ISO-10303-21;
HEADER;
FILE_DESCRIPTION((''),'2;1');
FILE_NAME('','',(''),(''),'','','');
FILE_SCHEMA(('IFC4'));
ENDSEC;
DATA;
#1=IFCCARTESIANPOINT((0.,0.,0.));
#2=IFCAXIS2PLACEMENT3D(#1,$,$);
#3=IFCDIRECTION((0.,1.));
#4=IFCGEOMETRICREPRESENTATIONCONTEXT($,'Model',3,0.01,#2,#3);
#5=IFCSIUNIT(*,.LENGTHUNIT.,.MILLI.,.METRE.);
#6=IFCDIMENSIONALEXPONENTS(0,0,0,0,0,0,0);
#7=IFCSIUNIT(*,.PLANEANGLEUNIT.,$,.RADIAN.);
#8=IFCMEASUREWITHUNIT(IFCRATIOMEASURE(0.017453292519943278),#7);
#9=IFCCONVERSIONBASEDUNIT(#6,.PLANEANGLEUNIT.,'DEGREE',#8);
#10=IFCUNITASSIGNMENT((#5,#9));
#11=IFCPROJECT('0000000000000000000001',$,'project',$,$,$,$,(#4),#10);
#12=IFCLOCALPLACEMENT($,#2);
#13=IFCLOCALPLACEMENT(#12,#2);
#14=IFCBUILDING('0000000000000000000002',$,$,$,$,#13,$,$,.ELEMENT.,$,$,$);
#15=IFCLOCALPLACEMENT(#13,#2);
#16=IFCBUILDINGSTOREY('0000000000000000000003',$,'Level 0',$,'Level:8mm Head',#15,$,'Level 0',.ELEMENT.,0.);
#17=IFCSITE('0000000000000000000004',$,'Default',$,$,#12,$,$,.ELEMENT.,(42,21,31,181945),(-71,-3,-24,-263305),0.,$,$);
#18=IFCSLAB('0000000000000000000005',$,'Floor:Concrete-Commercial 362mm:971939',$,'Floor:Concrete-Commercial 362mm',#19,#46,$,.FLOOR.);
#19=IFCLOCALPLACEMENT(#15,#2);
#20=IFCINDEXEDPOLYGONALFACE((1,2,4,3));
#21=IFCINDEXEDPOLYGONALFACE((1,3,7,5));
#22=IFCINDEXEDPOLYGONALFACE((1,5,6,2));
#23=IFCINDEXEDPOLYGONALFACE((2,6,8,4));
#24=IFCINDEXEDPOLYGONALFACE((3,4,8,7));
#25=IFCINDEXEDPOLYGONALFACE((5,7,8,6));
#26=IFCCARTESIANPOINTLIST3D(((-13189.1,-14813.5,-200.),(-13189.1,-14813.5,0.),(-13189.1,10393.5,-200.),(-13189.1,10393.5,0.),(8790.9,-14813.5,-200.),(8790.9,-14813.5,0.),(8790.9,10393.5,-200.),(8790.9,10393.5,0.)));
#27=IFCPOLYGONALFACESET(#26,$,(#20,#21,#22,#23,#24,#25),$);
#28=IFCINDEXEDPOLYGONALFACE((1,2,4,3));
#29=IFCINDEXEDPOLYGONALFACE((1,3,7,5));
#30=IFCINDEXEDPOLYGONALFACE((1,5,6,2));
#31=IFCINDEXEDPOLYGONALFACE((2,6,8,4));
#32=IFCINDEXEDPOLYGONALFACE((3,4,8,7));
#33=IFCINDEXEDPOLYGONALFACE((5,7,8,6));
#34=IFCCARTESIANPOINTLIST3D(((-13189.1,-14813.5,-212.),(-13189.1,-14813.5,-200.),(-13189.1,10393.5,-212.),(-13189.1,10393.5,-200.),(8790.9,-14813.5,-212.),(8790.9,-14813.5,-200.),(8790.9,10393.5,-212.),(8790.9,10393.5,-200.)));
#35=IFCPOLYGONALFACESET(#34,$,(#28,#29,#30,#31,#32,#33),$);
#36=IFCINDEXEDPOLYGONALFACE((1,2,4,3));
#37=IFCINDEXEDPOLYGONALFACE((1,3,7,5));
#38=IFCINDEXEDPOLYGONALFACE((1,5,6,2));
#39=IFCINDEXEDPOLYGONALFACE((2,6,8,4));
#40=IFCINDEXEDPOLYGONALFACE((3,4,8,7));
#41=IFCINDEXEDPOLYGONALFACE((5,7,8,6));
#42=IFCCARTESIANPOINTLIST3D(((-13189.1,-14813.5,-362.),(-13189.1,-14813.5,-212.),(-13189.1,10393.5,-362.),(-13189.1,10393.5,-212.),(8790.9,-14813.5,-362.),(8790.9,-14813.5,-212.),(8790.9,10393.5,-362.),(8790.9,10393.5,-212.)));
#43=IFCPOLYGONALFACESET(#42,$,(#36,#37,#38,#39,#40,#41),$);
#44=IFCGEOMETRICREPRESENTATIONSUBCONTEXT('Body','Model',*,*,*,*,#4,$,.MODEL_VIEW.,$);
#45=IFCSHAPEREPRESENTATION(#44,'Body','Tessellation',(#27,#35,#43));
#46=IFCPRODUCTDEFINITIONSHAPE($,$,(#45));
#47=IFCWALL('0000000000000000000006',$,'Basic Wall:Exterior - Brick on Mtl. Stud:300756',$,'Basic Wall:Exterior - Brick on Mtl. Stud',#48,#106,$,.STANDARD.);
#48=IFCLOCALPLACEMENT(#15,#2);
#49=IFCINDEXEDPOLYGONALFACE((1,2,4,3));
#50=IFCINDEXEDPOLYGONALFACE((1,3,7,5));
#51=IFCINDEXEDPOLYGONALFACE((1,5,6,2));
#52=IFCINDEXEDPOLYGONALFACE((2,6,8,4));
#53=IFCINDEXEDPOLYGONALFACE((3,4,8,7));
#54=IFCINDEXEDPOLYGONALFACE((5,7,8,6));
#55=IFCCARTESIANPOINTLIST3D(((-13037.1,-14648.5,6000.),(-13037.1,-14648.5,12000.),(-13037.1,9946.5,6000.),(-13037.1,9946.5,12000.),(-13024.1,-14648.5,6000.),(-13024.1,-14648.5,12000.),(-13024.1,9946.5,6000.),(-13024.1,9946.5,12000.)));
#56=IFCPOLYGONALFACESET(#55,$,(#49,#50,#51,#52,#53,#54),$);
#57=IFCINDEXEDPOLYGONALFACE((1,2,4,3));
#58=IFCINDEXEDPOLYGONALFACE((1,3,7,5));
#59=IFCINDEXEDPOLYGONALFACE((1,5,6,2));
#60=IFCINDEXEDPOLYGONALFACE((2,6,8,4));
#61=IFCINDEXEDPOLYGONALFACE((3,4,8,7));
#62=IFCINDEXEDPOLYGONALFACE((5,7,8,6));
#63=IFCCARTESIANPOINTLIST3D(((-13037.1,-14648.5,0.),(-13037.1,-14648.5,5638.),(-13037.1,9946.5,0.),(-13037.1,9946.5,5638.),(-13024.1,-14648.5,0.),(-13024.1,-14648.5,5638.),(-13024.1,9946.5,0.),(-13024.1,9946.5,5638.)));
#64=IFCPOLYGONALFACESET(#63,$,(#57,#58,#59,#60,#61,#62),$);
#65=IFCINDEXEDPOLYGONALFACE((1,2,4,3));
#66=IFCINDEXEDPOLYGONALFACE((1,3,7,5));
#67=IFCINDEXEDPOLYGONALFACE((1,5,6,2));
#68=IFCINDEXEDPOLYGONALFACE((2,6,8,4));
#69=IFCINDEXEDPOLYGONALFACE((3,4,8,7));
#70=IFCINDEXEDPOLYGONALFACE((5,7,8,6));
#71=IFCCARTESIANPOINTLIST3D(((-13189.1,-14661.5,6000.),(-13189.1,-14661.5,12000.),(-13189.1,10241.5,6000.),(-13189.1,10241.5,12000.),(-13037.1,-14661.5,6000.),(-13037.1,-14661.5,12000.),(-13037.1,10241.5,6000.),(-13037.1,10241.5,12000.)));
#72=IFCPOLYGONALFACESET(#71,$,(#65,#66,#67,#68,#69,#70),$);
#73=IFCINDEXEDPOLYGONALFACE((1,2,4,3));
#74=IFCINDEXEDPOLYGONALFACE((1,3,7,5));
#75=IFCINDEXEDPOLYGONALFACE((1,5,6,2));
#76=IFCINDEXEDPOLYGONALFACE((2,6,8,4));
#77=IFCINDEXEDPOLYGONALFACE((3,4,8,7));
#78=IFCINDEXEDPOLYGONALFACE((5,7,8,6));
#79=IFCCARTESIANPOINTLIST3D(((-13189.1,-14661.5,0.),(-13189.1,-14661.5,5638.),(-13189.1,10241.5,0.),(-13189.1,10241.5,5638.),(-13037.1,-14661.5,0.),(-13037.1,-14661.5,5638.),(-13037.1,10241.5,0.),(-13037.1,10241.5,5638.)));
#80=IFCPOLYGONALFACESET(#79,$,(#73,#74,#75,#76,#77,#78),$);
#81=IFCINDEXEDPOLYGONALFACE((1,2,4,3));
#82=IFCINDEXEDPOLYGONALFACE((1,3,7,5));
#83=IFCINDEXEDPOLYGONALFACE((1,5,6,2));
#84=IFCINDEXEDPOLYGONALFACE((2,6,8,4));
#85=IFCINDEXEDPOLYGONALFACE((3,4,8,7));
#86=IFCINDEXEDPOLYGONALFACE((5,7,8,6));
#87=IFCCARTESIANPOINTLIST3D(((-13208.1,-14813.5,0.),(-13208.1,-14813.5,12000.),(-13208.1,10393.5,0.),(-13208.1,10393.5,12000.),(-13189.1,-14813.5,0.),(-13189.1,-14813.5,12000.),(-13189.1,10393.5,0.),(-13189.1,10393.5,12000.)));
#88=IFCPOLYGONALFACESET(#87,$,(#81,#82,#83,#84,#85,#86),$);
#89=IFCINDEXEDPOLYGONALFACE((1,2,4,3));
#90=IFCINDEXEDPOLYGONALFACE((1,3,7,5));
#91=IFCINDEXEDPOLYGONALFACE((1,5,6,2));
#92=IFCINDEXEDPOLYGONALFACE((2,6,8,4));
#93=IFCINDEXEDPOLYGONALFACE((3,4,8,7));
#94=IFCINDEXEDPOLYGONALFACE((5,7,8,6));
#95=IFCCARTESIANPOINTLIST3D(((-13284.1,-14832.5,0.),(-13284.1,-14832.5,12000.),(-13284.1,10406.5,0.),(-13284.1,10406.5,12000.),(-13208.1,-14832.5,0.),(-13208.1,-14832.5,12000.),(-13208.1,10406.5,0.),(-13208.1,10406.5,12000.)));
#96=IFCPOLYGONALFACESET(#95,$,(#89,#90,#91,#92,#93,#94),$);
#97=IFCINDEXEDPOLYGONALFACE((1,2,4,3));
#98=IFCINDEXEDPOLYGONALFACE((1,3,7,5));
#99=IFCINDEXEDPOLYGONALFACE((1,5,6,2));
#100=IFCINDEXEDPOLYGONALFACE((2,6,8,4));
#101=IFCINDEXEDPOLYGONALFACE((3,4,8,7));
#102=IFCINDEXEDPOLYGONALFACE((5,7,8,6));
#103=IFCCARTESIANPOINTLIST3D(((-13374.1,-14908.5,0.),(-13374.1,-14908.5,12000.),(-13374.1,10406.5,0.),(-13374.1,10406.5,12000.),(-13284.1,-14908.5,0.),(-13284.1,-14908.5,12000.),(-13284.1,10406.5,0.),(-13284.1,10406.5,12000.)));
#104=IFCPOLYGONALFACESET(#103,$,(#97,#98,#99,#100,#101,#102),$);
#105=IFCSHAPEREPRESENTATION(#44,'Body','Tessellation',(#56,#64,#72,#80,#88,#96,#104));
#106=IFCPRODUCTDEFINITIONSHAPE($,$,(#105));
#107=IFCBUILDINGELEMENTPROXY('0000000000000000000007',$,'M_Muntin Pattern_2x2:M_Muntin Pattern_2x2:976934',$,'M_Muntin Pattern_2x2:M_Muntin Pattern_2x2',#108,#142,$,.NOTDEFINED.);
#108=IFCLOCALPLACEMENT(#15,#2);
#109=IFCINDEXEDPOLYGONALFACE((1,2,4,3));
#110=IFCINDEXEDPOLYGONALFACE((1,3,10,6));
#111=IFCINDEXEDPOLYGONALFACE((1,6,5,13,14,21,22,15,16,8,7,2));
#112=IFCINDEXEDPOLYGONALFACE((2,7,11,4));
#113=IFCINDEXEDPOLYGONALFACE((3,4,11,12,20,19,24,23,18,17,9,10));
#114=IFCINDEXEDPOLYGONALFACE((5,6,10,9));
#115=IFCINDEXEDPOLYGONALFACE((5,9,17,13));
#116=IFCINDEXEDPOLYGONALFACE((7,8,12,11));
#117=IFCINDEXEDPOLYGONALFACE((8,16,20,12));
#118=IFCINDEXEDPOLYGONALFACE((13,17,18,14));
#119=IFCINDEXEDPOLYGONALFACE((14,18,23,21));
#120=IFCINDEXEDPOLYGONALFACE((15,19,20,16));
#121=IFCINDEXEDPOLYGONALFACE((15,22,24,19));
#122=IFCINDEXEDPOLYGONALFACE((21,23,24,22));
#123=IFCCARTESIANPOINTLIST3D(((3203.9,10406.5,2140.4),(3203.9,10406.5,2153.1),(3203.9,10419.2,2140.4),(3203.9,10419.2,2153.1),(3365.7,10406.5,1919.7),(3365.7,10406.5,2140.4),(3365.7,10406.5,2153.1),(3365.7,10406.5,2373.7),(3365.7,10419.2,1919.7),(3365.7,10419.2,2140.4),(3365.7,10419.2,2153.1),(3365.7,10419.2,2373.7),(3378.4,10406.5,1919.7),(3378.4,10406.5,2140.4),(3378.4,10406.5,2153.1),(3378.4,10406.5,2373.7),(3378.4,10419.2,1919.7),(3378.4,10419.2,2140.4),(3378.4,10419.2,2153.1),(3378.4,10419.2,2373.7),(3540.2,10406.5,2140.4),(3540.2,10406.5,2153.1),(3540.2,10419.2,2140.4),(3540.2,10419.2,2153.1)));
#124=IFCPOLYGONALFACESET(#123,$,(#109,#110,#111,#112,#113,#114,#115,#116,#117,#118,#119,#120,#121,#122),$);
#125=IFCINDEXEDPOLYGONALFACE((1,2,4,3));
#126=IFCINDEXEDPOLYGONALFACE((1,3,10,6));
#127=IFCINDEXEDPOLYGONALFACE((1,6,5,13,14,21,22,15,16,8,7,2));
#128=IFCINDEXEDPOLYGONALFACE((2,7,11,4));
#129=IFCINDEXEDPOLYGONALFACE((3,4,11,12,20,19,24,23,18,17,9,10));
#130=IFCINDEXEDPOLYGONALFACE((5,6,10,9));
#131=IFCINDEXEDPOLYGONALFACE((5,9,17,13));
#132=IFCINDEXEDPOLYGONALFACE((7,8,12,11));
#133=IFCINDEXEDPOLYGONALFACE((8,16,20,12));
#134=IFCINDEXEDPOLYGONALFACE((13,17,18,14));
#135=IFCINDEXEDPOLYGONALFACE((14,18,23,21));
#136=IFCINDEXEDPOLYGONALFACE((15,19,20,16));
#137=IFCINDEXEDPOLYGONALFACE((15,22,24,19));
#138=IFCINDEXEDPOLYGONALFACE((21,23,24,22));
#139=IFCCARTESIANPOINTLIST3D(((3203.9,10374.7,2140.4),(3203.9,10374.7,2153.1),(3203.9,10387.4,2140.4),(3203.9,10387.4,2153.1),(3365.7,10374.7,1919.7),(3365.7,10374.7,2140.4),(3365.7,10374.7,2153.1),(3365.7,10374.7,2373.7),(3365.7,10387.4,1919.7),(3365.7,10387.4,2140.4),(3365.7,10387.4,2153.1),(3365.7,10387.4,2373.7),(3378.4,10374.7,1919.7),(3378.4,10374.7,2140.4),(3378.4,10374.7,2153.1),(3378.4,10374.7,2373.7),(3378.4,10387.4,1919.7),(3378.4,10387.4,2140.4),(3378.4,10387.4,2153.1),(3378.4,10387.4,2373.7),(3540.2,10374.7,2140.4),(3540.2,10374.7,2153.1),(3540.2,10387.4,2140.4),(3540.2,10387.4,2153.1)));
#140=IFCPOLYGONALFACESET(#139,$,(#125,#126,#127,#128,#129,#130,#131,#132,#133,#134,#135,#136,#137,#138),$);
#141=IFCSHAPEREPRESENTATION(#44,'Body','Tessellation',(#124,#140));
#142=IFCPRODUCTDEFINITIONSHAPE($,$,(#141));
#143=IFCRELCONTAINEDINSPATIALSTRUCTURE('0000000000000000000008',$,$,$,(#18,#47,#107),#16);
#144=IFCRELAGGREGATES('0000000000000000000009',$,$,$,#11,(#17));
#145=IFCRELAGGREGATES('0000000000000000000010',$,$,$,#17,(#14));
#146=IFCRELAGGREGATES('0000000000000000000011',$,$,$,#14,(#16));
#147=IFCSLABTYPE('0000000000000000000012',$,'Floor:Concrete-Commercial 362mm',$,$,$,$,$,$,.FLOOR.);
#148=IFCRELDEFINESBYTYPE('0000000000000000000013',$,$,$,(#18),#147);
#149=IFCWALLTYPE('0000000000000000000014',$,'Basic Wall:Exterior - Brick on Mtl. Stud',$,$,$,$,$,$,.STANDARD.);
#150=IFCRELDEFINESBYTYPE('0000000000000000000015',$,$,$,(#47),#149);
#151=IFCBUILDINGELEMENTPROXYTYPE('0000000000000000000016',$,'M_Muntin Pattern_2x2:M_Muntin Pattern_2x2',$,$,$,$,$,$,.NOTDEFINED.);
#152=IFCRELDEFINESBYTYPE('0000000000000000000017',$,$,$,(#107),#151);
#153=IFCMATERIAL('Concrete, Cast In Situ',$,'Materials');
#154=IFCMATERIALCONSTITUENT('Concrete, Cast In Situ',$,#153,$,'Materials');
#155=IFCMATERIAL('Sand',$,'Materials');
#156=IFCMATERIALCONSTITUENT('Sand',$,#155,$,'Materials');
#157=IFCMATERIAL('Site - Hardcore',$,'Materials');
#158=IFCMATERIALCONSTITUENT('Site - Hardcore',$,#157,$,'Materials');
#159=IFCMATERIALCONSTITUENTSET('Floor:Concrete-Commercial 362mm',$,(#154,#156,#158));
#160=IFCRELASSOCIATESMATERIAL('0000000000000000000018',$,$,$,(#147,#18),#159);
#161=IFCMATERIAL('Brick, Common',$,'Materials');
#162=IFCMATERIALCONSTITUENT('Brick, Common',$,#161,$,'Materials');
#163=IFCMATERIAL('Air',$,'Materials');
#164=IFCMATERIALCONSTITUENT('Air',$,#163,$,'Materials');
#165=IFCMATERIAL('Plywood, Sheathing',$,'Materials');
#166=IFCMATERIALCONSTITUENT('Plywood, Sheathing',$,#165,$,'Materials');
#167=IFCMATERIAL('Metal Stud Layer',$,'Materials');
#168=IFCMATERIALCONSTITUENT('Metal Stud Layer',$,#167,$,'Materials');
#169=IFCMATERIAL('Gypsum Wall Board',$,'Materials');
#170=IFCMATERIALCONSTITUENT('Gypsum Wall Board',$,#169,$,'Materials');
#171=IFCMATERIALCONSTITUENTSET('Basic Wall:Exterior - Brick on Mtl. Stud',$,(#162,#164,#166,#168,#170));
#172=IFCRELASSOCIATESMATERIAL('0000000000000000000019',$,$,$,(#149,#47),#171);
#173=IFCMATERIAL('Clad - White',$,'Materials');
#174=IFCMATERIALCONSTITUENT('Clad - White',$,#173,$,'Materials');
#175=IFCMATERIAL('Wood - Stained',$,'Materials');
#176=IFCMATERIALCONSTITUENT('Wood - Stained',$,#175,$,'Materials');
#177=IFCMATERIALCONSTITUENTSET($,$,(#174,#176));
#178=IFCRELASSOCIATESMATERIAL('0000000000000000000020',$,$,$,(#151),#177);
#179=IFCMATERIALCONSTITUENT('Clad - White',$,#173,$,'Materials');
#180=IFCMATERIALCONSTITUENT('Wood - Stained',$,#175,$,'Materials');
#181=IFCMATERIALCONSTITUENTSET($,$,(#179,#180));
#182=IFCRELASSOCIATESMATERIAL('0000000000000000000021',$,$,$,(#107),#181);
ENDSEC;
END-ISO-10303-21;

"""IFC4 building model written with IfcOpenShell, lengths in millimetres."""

from ifc_helpers import new_model, entity, si_unit, converted_unit, direction, frame, origin, place, context, subcontext, project, spatial, indexed_curve, outline, extrude, source, transform, mapped, material, constituent, constituent_set, type_object, type_shapes, element, save


model = new_model("IFC4")

# Units and contexts
model_context = context("Model", 3, precision=0.01, world=origin(), true_north=direction((0.0, 1.0)))
body_context = subcontext(model_context, "Body", "Model", "MODEL_VIEW")
ifc_project = project(units=[si_unit("LENGTHUNIT", "METRE", prefix="MILLI"), converted_unit("PLANEANGLEUNIT", "DEGREE", entity("IfcRatioMeasure", 0.017453292519943278), si_unit("PLANEANGLEUNIT", "RADIAN"), dimensions=[0, 0, 0, 0, 0, 0, 0])], contexts=[model_context])

# Site, building, storey
site_placement = place(None, origin())
site = spatial("IfcSite", under=ifc_project, at=site_placement, Name="Default", CompositionType="ELEMENT", RefLatitude=(42, 21, 31, 181945), RefLongitude=(-71, -3, -24, -263305), RefElevation=0.0)
building_placement = place(site_placement, origin())
building = spatial("IfcBuilding", under=site, at=building_placement, CompositionType="ELEMENT")
storey_placement = place(building_placement, origin())
storey = spatial("IfcBuildingStorey", under=building, at=storey_placement, Name="Level 0", ObjectType="Level:8mm Head", LongName="Level 0", CompositionType="ELEMENT", Elevation=0.0)

# Slab
ifc_material_1 = material(Name="Concrete, Cast In Situ", Category="Materials")
ifc_constituent_1 = constituent(ifc_material_1, Name="Concrete, Cast In Situ", Category="Materials")
ifc_material_2 = material(Name="Sand", Category="Materials")
ifc_constituent_2 = constituent(ifc_material_2, Name="Sand", Category="Materials")
ifc_material_3 = material(Name="Site - Hardcore", Category="Materials")
ifc_constituent_3 = constituent(ifc_material_3, Name="Site - Hardcore", Category="Materials")
ifc_constituent_set_1 = constituent_set(constituents=[ifc_constituent_1, ifc_constituent_2, ifc_constituent_3], Name="Floor:Concrete-Commercial 362mm")
slab_type = type_object("IfcSlabType", Name="Floor:Concrete-Commercial 362mm", PredefinedType="FLOOR", material=ifc_constituent_set_1)
slab_placement = place(storey_placement, origin())
element("IfcSlab", 1, at=slab_placement, inside=storey, type_object=slab_type, material=ifc_constituent_set_1, Name="Floor:Concrete-Commercial 362mm:971939", ObjectType="Floor:Concrete-Commercial 362mm", PredefinedType="FLOOR", context=body_context, shape_type="SweptSolid", body=[
    extrude(outline(indexed_curve([(-10990.0, -12603.5), (10990.0, -12603.5), (10990.0, 12603.5), (-10990.0, 12603.5), (-10990.0, -12603.5)], self_intersect=False)), frame((-2199.1, -2210.0, -200.0), z_axis=(0.0, 0.0, 1.0), x_axis=(-1.0, 0.0, 0.0)), (0.0, 0.0, 1.0), 200.0),
    extrude(outline(indexed_curve([(-10990.0, -12603.5), (10990.0, -12603.5), (10990.0, 12603.5), (-10990.0, 12603.5), (-10990.0, -12603.5)], self_intersect=False)), frame((-2199.1, -2210.0, -212.0), z_axis=(0.0, 0.0, 1.0), x_axis=(-1.0, 0.0, 0.0)), (0.0, 0.0, 1.0), 12.0),
    extrude(outline(indexed_curve([(-10990.0, -12603.5), (10990.0, -12603.5), (10990.0, 12603.5), (-10990.0, 12603.5), (-10990.0, -12603.5)], self_intersect=False)), frame((-2199.1, -2210.0, -362.0), z_axis=(0.0, 0.0, 1.0), x_axis=(-1.0, 0.0, 0.0)), (0.0, 0.0, 1.0), 150.0),
])

# Shared definitions
ifc_material_4 = material(Name="Air", Category="Materials")
ifc_material_5 = material(Name="Plywood, Sheathing", Category="Materials")
ifc_material_6 = material(Name="Metal Stud Layer", Category="Materials")
ifc_material_7 = material(Name="Gypsum Wall Board", Category="Materials")
ifc_material_8 = material(Name="Brick, Common", Category="Materials")
ifc_constituent_4 = constituent(ifc_material_8, Name="Brick, Common", Category="Materials")
ifc_constituent_5 = constituent(ifc_material_4, Name="Air", Category="Materials")
ifc_constituent_6 = constituent(ifc_material_5, Name="Plywood, Sheathing", Category="Materials")
ifc_constituent_7 = constituent(ifc_material_6, Name="Metal Stud Layer", Category="Materials")
ifc_constituent_8 = constituent(ifc_material_7, Name="Gypsum Wall Board", Category="Materials")
ifc_constituent_set_2 = constituent_set(constituents=[ifc_constituent_4, ifc_constituent_5, ifc_constituent_6, ifc_constituent_7, ifc_constituent_8], Name="Basic Wall:Exterior - Brick on Mtl. Stud")
wall_type_1 = type_object("IfcWallType", Name="Basic Wall:Exterior - Brick on Mtl. Stud", PredefinedType="STANDARD", material=ifc_constituent_set_2)

# Wall
wall_1_placement = place(storey_placement, frame((-13199.1, -14648.5, 0.0), z_axis=(0.0, 0.0, 1.0), x_axis=(0.0, 1.0, 0.0)))
element("IfcWall", 2, at=wall_1_placement, inside=storey, type_object=wall_type_1, material=ifc_constituent_set_2, Name="Basic Wall:Exterior - Brick on Mtl. Stud:300756", ObjectType="Basic Wall:Exterior - Brick on Mtl. Stud", PredefinedType="STANDARD", context=body_context, shape_type="SweptSolid", body=[
    extrude(outline(indexed_curve([(-3000.0, -12297.5), (3000.0, -12297.5), (3000.0, 12297.5), (-3000.0, 12297.5), (-3000.0, -12297.5)], self_intersect=False)), frame((12297.5, -162.0, 9000.0), z_axis=(0.0, -1.0, 0.0), x_axis=(0.0, 0.0, -1.0)), (0.0, 0.0, 1.0), 13.0),
    extrude(outline(indexed_curve([(-2819.0, -12297.5), (2819.0, -12297.5), (2819.0, 12297.5), (-2819.0, 12297.5), (-2819.0, -12297.5)], self_intersect=False)), frame((12297.5, -162.0, 2819.0), z_axis=(0.0, -1.0, 0.0), x_axis=(0.0, 0.0, 1.0)), (0.0, 0.0, 1.0), 13.0),
    extrude(outline(indexed_curve([(-3000.0, -12451.5), (3000.0, -12451.5), (3000.0, 12451.5), (-3000.0, 12451.5), (-3000.0, -12451.5)], self_intersect=False)), frame((12438.5, -10.0, 9000.0), z_axis=(0.0, -1.0, 0.0), x_axis=(0.0, 0.0, -1.0)), (0.0, 0.0, 1.0), 152.0),
    extrude(outline(indexed_curve([(-2819.0, -12451.5), (2819.0, -12451.5), (2819.0, 12451.5), (-2819.0, 12451.5), (-2819.0, -12451.5)], self_intersect=False)), frame((12438.5, -10.0, 2819.0), z_axis=(0.0, -1.0, 0.0), x_axis=(0.0, 0.0, 1.0)), (0.0, 0.0, 1.0), 152.0),
    extrude(outline(indexed_curve([(-12603.5, -9.5), (12603.5, -9.5), (12603.5, 9.5), (-12603.5, 9.5), (-12603.5, -9.5)], self_intersect=False)), frame((12438.5, -0.5, 0.0)), (0.0, 0.0, 1.0), 12000.0),
    extrude(outline(indexed_curve([(-12619.5, -38.0), (12619.5, -38.0), (12619.5, 38.0), (-12619.5, 38.0), (-12619.5, -38.0)], self_intersect=False)), frame((12435.5, 47.0, 0.0)), (0.0, 0.0, 1.0), 12000.0),
    extrude(outline(indexed_curve([(-45.0, -12657.5), (45.0, -12657.5), (45.0, 12657.5), (-45.0, 12657.5), (-45.0, -12657.5)], self_intersect=False)), frame((12397.5, 130.0, 0.0), z_axis=(0.0, 0.0, 1.0), x_axis=(0.0, -1.0, 0.0)), (0.0, 0.0, 1.0), 12000.0),
])

# Building element proxy
ifc_material_9 = material(Name="Clad - White", Category="Materials")
ifc_constituent_9 = constituent(ifc_material_9, Name="Clad - White", Category="Materials")
ifc_material_10 = material(Name="Wood - Stained", Category="Materials")
ifc_constituent_10 = constituent(ifc_material_10, Name="Wood - Stained", Category="Materials")
ifc_constituent_set_3 = constituent_set(constituents=[ifc_constituent_9, ifc_constituent_10])
ifc_constituent_11 = constituent(ifc_material_9, Name="Clad - White", Category="Materials")
ifc_constituent_12 = constituent(ifc_material_10, Name="Wood - Stained", Category="Materials")
ifc_constituent_set_4 = constituent_set(constituents=[ifc_constituent_11, ifc_constituent_12])
building_element_proxy_type_1 = type_object("IfcBuildingElementProxyType", Name="M_Muntin Pattern_2x2:M_Muntin Pattern_2x2", PredefinedType="NOTDEFINED", material=ifc_constituent_set_4)
shared_shape_1 = source(origin(), body_context, "Body", "SweptSolid", [
    extrude(outline(indexed_curve([(6.4, -6.4), (227.0, -6.4), (227.0, 6.3), (6.4, 6.3), (6.4, 168.2), (-6.3, 168.2), (-6.3, 6.3), (-227.0, 6.3), (-227.0, -6.4), (-6.3, -6.4), (-6.3, -168.1), (6.4, -168.1), (6.4, -6.4)], self_intersect=False)), frame((0.0, 9.5, 227.0), z_axis=(0.0, 1.0, 0.0), x_axis=(0.0, 0.0, 1.0)), (0.0, 0.0, 1.0), 12.7),
    extrude(outline(indexed_curve([(6.4, -6.4), (227.0, -6.4), (227.0, 6.3), (6.4, 6.3), (6.4, 168.2), (-6.3, 168.2), (-6.3, 6.3), (-227.0, 6.3), (-227.0, -6.4), (-6.3, -6.4), (-6.3, -168.1), (6.4, -168.1), (6.4, -6.4)], self_intersect=False)), frame((0.0, -22.2, 227.0), z_axis=(0.0, 1.0, 0.0), x_axis=(0.0, 0.0, 1.0)), (0.0, 0.0, 1.0), 12.7),
])
type_shapes(building_element_proxy_type_1, [shared_shape_1])
proxy_1_placement = place(storey_placement, frame((3372.1, 10396.9, 1919.7)))
element("IfcBuildingElementProxy", 3, at=proxy_1_placement, inside=storey, type_object=building_element_proxy_type_1, material=ifc_constituent_set_3, Name="M_Muntin Pattern_2x2:M_Muntin Pattern_2x2:976934", ObjectType="M_Muntin Pattern_2x2:M_Muntin Pattern_2x2", PredefinedType="NOTDEFINED", context=body_context, shape_type="MappedRepresentation", body=[
    mapped(shared_shape_1, transform((0.0, 0.0, 0.0), scale=1.0)),
])

save(model, "model.ifc")
